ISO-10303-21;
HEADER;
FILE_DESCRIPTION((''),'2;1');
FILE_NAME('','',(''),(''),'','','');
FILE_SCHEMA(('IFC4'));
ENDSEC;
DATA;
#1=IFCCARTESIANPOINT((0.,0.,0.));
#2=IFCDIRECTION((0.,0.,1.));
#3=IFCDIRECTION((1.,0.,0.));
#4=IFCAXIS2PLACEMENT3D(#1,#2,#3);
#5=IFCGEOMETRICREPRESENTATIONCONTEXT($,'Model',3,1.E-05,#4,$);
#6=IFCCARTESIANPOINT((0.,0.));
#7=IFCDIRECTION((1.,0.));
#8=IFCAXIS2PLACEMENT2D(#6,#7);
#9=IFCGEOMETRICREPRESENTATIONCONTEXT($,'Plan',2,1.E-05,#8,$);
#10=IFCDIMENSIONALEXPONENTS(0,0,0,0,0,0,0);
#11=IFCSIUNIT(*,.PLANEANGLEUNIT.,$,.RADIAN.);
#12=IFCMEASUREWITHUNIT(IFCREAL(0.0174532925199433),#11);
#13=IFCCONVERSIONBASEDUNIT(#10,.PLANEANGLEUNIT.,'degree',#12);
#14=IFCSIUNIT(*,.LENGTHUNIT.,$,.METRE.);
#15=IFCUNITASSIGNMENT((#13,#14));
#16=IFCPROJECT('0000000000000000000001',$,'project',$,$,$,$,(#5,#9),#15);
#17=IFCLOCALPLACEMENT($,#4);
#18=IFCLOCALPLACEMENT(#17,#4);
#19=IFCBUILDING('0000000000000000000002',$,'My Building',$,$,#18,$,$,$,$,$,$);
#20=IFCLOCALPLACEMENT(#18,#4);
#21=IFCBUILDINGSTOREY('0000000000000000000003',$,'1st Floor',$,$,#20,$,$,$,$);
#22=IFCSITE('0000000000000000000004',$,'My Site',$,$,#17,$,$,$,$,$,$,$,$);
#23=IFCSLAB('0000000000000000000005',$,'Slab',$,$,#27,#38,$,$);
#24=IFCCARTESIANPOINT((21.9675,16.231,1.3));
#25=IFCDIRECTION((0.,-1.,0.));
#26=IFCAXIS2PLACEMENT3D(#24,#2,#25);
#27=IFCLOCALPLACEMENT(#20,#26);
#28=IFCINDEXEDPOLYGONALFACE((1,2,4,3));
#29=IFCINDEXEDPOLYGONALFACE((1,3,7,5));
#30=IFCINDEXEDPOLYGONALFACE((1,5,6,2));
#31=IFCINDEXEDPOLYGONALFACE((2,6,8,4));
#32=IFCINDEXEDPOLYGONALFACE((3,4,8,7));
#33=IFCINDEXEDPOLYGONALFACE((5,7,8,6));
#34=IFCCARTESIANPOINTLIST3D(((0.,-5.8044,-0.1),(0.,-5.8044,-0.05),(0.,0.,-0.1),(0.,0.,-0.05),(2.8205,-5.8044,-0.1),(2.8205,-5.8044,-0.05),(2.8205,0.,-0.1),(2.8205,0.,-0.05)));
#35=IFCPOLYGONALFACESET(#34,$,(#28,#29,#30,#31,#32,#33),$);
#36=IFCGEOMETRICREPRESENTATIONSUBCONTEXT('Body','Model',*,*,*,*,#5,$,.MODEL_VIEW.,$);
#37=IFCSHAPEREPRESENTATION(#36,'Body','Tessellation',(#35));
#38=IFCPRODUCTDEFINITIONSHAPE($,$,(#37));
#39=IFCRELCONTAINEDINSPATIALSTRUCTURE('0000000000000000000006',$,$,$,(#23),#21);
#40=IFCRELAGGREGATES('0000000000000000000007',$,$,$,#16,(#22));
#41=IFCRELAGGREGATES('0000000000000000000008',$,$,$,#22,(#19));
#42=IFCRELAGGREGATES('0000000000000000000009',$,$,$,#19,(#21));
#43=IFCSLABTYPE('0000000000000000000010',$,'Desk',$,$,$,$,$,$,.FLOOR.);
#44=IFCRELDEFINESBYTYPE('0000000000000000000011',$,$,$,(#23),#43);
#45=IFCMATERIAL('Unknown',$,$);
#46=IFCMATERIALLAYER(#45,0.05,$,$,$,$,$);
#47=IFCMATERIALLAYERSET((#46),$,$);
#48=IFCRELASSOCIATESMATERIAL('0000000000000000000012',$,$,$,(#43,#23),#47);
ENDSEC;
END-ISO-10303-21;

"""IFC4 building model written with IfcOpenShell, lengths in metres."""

from ifc_helpers import new_model, entity, si_unit, converted_unit, frame, origin_with_axes, origin_2d_with_axis, place, context, subcontext, project, spatial, indexed_curve, outline, extrude, material, layer, layer_set, layer_usage, type_object, element, save


model = new_model("IFC4")

# Units and contexts
model_context = context("Model", 3, precision=1e-05, world=origin_with_axes())
plan_context = context("Plan", 2, precision=1e-05, world=origin_2d_with_axis())
body_context = subcontext(model_context, "Body", "Model", "MODEL_VIEW")
ifc_project = project(units=[converted_unit("PLANEANGLEUNIT", "degree", entity("IfcReal", 0.0174532925199433), si_unit("PLANEANGLEUNIT", "RADIAN"), dimensions=[0, 0, 0, 0, 0, 0, 0]), si_unit("LENGTHUNIT", "METRE")], contexts=[model_context, plan_context])

# Site, building, storey
site_placement = place(None, origin_with_axes())
site = spatial("IfcSite", under=ifc_project, at=site_placement, Name="My Site")
building_placement = place(site_placement, origin_with_axes())
building = spatial("IfcBuilding", under=site, at=building_placement, Name="My Building")
storey_placement = place(building_placement, origin_with_axes())
storey = spatial("IfcBuildingStorey", under=building, at=storey_placement, Name="1st Floor")

# Shared definitions
ifc_material = material(Name="Unknown")

# Slab
ifc_layer_1 = layer(ifc_material, 0.05)
ifc_layer_set_1 = layer_set([ifc_layer_1])
slab_type = type_object("IfcSlabType", Name="Desk", PredefinedType="FLOOR", material=ifc_layer_set_1)
ifc_layer_usage_1 = layer_usage(ifc_layer_set_1, "AXIS3", "POSITIVE", -0.1)
slab_1_placement = place(storey_placement, frame((21.9675, 16.231, 1.3), z_axis=(0.0, 0.0, 1.0), x_axis=(0.0, -1.0, 0.0)))
element("IfcSlab", 1, at=slab_1_placement, inside=storey, type_object=slab_type, material=ifc_layer_usage_1, Name="Slab", context=body_context, shape_type="SweptSolid", body=[
    extrude(outline(indexed_curve([(0.0, 0.0), (2.8205, 0.0), (2.8205, -5.8044), (0.0, -5.8044), (0.0, 0.0)])), frame((0.0, 0.0, -0.1), z_axis=(0.0, 0.0, 1.0), x_axis=(1.0, 0.0, 0.0)), (0.0, 0.0, 1.0), 0.05),
])

save(model, "model.ifc")
